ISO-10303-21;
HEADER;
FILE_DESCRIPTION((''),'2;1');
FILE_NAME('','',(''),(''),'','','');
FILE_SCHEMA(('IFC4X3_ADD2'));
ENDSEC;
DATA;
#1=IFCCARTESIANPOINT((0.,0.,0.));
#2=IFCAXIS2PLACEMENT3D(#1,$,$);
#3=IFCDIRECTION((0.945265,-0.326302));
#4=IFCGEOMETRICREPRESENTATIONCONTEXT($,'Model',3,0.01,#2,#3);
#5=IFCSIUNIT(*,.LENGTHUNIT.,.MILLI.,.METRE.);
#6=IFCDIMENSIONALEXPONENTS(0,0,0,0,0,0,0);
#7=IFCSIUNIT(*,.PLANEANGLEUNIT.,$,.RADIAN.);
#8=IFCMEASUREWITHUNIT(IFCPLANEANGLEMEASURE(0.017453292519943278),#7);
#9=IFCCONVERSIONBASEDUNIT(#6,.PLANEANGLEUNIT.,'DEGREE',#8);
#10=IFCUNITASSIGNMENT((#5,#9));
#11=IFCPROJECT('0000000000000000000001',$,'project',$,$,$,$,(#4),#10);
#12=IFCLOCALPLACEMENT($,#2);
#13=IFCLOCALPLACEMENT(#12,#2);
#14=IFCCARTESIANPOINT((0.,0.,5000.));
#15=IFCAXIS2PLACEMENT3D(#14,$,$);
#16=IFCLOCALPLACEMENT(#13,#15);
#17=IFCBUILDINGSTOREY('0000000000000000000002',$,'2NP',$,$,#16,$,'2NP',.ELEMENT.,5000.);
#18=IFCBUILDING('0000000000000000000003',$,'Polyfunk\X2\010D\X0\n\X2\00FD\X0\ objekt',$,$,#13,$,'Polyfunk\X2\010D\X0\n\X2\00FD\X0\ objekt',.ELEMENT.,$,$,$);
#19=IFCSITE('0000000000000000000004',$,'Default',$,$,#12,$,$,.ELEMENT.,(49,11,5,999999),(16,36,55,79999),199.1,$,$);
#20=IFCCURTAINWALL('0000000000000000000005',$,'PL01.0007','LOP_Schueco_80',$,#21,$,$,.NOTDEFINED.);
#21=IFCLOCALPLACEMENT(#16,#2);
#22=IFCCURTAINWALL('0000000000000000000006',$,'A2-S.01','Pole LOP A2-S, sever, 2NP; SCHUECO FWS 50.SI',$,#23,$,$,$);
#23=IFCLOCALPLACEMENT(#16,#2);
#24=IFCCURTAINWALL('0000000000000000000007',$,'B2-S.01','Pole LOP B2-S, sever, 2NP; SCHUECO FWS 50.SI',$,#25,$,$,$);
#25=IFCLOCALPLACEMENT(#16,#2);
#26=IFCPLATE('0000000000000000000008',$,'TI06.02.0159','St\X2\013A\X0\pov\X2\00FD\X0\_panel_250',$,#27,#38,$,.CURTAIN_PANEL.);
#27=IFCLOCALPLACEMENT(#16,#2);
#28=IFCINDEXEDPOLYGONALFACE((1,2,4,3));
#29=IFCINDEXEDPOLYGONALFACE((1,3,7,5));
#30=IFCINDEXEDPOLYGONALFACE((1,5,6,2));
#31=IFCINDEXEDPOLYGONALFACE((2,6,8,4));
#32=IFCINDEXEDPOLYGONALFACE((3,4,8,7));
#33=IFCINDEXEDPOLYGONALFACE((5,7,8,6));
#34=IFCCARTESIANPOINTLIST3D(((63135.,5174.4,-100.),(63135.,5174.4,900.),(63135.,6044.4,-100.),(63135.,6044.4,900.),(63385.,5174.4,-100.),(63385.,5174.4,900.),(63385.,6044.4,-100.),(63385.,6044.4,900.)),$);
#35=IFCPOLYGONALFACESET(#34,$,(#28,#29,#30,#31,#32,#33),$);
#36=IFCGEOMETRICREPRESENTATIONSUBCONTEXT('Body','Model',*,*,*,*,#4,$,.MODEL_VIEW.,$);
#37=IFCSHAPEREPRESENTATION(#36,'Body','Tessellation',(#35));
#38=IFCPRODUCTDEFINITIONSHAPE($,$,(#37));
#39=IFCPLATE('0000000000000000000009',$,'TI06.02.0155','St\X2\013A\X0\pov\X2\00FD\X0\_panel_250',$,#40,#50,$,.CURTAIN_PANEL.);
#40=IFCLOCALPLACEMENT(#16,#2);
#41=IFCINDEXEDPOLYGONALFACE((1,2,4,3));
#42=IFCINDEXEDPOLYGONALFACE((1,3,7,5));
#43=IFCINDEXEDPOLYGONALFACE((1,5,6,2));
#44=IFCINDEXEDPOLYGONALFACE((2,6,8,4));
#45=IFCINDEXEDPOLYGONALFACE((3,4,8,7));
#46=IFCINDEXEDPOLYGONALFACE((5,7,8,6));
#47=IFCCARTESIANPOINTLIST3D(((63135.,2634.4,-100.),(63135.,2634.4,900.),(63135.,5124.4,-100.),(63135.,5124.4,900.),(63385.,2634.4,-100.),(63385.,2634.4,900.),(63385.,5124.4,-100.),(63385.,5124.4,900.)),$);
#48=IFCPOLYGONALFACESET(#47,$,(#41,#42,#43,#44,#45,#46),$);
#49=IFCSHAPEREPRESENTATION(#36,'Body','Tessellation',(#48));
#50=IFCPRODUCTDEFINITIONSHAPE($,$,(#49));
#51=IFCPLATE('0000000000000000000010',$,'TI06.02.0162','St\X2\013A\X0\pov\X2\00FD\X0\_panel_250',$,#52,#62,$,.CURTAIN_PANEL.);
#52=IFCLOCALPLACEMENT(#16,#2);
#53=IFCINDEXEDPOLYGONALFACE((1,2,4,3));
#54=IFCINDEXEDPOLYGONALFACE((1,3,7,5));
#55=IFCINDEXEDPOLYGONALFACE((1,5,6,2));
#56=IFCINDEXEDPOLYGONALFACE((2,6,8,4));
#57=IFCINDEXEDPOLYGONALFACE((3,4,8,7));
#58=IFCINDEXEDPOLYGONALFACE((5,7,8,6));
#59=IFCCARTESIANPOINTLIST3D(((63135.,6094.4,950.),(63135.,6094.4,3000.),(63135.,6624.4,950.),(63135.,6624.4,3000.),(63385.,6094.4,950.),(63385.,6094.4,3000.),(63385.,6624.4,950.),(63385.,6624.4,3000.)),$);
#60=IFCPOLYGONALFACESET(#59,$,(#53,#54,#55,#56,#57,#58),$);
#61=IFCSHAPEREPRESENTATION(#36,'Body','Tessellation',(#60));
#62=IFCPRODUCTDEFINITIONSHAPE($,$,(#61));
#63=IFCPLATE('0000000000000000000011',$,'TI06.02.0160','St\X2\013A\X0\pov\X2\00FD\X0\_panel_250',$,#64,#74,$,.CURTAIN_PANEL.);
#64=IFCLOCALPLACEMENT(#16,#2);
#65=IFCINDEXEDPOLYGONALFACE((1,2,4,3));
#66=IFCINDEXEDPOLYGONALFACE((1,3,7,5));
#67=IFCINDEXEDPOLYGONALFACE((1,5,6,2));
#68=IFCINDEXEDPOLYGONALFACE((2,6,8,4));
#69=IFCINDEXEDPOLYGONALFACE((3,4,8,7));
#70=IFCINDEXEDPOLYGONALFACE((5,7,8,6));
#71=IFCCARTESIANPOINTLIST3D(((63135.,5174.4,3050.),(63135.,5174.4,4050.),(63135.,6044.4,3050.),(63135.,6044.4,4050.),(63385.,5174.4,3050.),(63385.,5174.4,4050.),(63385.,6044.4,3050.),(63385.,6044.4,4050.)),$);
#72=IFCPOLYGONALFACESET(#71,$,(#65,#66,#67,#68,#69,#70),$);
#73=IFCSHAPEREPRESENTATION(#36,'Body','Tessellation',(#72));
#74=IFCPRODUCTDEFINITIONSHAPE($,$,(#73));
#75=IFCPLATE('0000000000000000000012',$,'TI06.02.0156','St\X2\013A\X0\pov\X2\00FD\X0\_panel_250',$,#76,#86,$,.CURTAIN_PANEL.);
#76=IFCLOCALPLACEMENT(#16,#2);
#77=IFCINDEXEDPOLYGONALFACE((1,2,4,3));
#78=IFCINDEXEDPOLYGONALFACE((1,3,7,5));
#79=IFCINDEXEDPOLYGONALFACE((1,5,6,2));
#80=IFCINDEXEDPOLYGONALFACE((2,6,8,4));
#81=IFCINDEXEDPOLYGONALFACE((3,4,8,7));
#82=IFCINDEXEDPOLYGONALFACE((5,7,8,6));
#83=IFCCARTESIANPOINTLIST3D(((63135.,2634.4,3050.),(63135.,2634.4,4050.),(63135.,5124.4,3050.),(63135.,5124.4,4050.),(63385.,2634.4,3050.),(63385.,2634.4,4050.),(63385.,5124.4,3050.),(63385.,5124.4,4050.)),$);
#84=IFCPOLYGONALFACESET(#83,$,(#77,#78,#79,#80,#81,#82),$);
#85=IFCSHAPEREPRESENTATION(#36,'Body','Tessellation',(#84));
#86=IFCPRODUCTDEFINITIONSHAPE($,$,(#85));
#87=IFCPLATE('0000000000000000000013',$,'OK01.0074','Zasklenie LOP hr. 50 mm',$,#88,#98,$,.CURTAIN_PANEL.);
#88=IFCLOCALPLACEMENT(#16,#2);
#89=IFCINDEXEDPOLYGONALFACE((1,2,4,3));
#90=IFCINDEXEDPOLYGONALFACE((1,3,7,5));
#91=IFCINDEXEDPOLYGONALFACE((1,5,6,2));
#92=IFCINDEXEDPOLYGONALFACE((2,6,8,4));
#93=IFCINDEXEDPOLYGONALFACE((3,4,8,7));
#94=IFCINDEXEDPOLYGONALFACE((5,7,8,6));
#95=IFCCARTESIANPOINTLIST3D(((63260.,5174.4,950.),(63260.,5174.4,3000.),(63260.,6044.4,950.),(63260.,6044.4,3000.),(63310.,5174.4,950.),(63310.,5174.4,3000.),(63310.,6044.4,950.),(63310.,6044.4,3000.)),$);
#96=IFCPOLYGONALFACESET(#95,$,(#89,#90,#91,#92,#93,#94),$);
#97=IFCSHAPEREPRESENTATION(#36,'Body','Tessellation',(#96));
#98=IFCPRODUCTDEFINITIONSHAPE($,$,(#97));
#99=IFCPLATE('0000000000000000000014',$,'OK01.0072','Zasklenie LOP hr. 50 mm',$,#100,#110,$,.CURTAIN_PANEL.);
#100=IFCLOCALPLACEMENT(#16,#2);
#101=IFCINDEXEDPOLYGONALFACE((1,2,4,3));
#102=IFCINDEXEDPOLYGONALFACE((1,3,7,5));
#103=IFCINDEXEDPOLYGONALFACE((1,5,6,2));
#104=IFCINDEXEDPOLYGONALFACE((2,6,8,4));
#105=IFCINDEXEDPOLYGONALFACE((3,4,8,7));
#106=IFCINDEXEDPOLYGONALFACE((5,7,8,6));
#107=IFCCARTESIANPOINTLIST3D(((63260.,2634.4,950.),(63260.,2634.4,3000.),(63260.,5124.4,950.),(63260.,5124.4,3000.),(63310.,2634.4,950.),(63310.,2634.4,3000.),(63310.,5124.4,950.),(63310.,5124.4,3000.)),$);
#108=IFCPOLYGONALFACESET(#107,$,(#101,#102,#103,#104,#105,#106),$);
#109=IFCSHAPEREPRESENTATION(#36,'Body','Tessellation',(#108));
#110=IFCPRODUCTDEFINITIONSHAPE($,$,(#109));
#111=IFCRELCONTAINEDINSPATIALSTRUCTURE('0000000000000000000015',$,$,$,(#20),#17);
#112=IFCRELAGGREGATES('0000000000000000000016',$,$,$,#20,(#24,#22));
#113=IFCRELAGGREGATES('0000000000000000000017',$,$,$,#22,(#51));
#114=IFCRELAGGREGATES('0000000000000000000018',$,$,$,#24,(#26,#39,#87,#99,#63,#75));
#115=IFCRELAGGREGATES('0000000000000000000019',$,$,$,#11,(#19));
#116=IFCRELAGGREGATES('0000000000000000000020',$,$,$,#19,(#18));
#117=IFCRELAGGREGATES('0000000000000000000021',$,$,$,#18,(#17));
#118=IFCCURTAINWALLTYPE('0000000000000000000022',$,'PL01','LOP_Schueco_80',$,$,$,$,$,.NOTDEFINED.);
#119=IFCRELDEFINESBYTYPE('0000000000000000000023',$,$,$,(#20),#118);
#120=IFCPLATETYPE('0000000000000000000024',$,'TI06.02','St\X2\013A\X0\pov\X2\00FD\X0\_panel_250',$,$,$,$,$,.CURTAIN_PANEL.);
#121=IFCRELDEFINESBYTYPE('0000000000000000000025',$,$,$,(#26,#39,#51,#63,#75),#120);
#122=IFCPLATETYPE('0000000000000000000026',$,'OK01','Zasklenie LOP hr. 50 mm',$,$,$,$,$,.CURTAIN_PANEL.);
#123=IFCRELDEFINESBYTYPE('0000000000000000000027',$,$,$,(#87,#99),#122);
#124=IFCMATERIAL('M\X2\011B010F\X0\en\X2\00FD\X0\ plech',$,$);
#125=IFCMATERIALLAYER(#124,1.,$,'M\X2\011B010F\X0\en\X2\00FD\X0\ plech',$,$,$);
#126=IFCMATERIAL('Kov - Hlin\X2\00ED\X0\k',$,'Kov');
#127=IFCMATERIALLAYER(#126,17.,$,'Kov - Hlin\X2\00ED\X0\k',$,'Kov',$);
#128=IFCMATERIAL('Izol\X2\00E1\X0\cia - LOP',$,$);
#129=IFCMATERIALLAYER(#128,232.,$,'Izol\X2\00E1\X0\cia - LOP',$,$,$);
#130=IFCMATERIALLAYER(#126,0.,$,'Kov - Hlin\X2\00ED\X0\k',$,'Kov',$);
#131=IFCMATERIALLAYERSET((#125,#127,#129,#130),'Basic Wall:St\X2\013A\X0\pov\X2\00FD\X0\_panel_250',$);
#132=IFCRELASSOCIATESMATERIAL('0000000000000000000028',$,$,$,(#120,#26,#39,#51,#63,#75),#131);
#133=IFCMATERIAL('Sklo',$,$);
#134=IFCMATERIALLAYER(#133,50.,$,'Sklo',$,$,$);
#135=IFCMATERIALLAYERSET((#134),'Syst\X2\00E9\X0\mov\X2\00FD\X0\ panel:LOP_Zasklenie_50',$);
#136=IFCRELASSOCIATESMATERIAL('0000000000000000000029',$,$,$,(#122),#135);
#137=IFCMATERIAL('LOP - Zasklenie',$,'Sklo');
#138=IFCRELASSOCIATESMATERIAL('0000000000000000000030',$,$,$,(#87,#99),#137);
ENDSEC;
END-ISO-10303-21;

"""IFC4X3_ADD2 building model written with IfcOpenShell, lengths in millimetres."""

from ifc_helpers import new_model, entity, si_unit, converted_unit, direction, frame, frame_2d, origin, origin_2d_with_axis, place, context, subcontext, project, spatial, rectangle, extrude, source, transform, mapped, material, layer, layer_set, layer_usage, type_object, type_shapes, element, aggregate, save


model = new_model("IFC4X3_ADD2")

# Units and contexts
model_context = context("Model", 3, precision=0.01, world=origin(), true_north=direction((0.945265, -0.326302)))
body_context = subcontext(model_context, "Body", "Model", "MODEL_VIEW")
ifc_project = project(units=[si_unit("LENGTHUNIT", "METRE", prefix="MILLI"), converted_unit("PLANEANGLEUNIT", "DEGREE", entity("IfcPlaneAngleMeasure", 0.017453292519943278), si_unit("PLANEANGLEUNIT", "RADIAN"), dimensions=[0, 0, 0, 0, 0, 0, 0])], contexts=[model_context])

# Site, building, storey
site_placement = place(None, origin())
site = spatial("IfcSite", under=ifc_project, at=site_placement, Name="Default", CompositionType="ELEMENT", RefLatitude=(49, 11, 5, 999999), RefLongitude=(16, 36, 55, 79999), RefElevation=199.1)
building_placement = place(site_placement, origin())
building = spatial("IfcBuilding", under=site, at=building_placement, Name="Polyfunkčný objekt", LongName="Polyfunkčný objekt", CompositionType="ELEMENT")
storey_placement = place(building_placement, frame((0.0, 0.0, 5000.0)))
storey = spatial("IfcBuildingStorey", under=building, at=storey_placement, Name="2NP", LongName="2NP", CompositionType="ELEMENT", Elevation=5000.0)

# Curtain walls, plates
curtain_wall_type = type_object("IfcCurtainWallType", Name="PL01", Description="LOP_Schueco_80", PredefinedType="NOTDEFINED")
curtain_wall_1_placement = place(storey_placement, frame((0.0, 0.0, -5000.0)))
curtain_wall_1 = element("IfcCurtainWall", 1, at=curtain_wall_1_placement, inside=storey, type_object=curtain_wall_type, Name="PL01.0007", Description="LOP_Schueco_80", PredefinedType="NOTDEFINED")
curtain_wall_2 = element("IfcCurtainWall", 2, Name="A2-S.01", Description="Pole LOP A2-S, sever, 2NP; SCHUECO FWS 50.SI")
curtain_wall_3 = element("IfcCurtainWall", 3, Name="B2-S.01", Description="Pole LOP B2-S, sever, 2NP; SCHUECO FWS 50.SI")
aggregate(curtain_wall_1, [curtain_wall_3, curtain_wall_2])
ifc_material_1 = material(Name="Měďený plech")
ifc_layer_1 = layer(ifc_material_1, 1.0, Name="Měďený plech")
ifc_material_2 = material(Name="Kov - Hliník", Category="Kov")
ifc_layer_2 = layer(ifc_material_2, 17.0, Name="Kov - Hliník", Category="Kov")
ifc_material_3 = material(Name="Izolácia - LOP")
ifc_layer_3 = layer(ifc_material_3, 232.0, Name="Izolácia - LOP")
ifc_layer_4 = layer(ifc_material_2, 0.0, Name="Kov - Hliník", Category="Kov")
ifc_layer_set_1 = layer_set([ifc_layer_1, ifc_layer_2, ifc_layer_3, ifc_layer_4], Name="Basic Wall:Stĺpový_panel_250")
ifc_layer_usage_1 = layer_usage(ifc_layer_set_1, "AXIS2", "NEGATIVE", 125.0)
plate_type_1 = type_object("IfcPlateType", Name="TI06.02", Description="Stĺpový_panel_250", PredefinedType="CURTAIN_PANEL", material=ifc_layer_set_1)
plate_1_placement = place(storey_placement, frame((63260.0, 6044.4, -100.0), z_axis=(0.0, 0.0, 1.0), x_axis=(0.0, -1.0, 0.0)))
plate_1 = element("IfcPlate", 4, at=plate_1_placement, type_object=plate_type_1, material=ifc_layer_usage_1, Name="TI06.02.0159", Description="Stĺpový_panel_250", PredefinedType="CURTAIN_PANEL", context=body_context, shape_type="SweptSolid", body=[
    extrude(rectangle(XDim=250.0, YDim=870.0, at=frame_2d((0.0, 0.0), x_axis=(1.0, 0.0))), frame((435.0, 0.0, 0.0), z_axis=(0.0, 0.0, 1.0), x_axis=(0.0, 1.0, 0.0)), (0.0, 0.0, 1.0), 1000.0),
])
ifc_layer_usage_2 = layer_usage(ifc_layer_set_1, "AXIS2", "NEGATIVE", 125.0)
plate_2_placement = place(storey_placement, frame((63260.0, 5124.4, -100.0), z_axis=(0.0, 0.0, 1.0), x_axis=(0.0, -1.0, 0.0)))
plate_2 = element("IfcPlate", 5, at=plate_2_placement, type_object=plate_type_1, material=ifc_layer_usage_2, Name="TI06.02.0155", Description="Stĺpový_panel_250", PredefinedType="CURTAIN_PANEL", context=body_context, shape_type="SweptSolid", body=[
    extrude(rectangle(XDim=250.0, YDim=2490.0, at=origin_2d_with_axis()), frame((1245.0, 0.0, 0.0), z_axis=(0.0, 0.0, 1.0), x_axis=(0.0, 1.0, 0.0)), (0.0, 0.0, 1.0), 1000.0),
])
ifc_layer_usage_3 = layer_usage(ifc_layer_set_1, "AXIS2", "NEGATIVE", 125.0)
plate_3_placement = place(storey_placement, frame((63260.0, 6624.4, 950.0), z_axis=(0.0, 0.0, 1.0), x_axis=(0.0, -1.0, 0.0)))
plate_3 = element("IfcPlate", 6, at=plate_3_placement, type_object=plate_type_1, material=ifc_layer_usage_3, Name="TI06.02.0162", Description="Stĺpový_panel_250", PredefinedType="CURTAIN_PANEL", context=body_context, shape_type="SweptSolid", body=[
    extrude(rectangle(XDim=250.0, YDim=530.0, at=frame_2d((0.0, 0.0), x_axis=(1.0, 0.0))), frame((265.0, 0.0, 0.0), z_axis=(0.0, 0.0, 1.0), x_axis=(0.0, 1.0, 0.0)), (0.0, 0.0, 1.0), 2050.0),
])
aggregate(curtain_wall_2, [plate_3])
ifc_layer_usage_4 = layer_usage(ifc_layer_set_1, "AXIS2", "NEGATIVE", 125.0)
plate_4_placement = place(storey_placement, frame((63260.0, 6044.4, 3050.0), z_axis=(0.0, 0.0, 1.0), x_axis=(0.0, -1.0, 0.0)))
plate_4 = element("IfcPlate", 7, at=plate_4_placement, type_object=plate_type_1, material=ifc_layer_usage_4, Name="TI06.02.0160", Description="Stĺpový_panel_250", PredefinedType="CURTAIN_PANEL", context=body_context, shape_type="SweptSolid", body=[
    extrude(rectangle(XDim=250.0, YDim=870.0, at=frame_2d((0.0, 0.0), x_axis=(1.0, 0.0))), frame((435.0, 0.0, 0.0), z_axis=(0.0, 0.0, 1.0), x_axis=(0.0, 1.0, 0.0)), (0.0, 0.0, 1.0), 1000.0),
])
ifc_layer_usage_5 = layer_usage(ifc_layer_set_1, "AXIS2", "NEGATIVE", 125.0)
plate_5_placement = place(storey_placement, frame((63260.0, 5124.4, 3050.0), z_axis=(0.0, 0.0, 1.0), x_axis=(0.0, -1.0, 0.0)))
plate_5 = element("IfcPlate", 8, at=plate_5_placement, type_object=plate_type_1, material=ifc_layer_usage_5, Name="TI06.02.0156", Description="Stĺpový_panel_250", PredefinedType="CURTAIN_PANEL", context=body_context, shape_type="SweptSolid", body=[
    extrude(rectangle(XDim=250.0, YDim=2490.0, at=frame_2d((0.0, 0.0), x_axis=(1.0, 0.0))), frame((1245.0, 0.0, 0.0), z_axis=(0.0, 0.0, 1.0), x_axis=(0.0, 1.0, 0.0)), (0.0, 0.0, 1.0), 1000.0),
])
ifc_material_4 = material(Name="LOP - Zasklenie", Category="Sklo")
ifc_material_5 = material(Name="Sklo")
ifc_layer_5 = layer(ifc_material_5, 50.0, Name="Sklo")
ifc_layer_set_2 = layer_set([ifc_layer_5], Name="Systémový panel:LOP_Zasklenie_50")
plate_type_2 = type_object("IfcPlateType", Name="OK01", Description="Zasklenie LOP hr. 50 mm", PredefinedType="CURTAIN_PANEL", material=ifc_layer_set_2)
shared_shape_1 = source(origin(), body_context, "Body", "SweptSolid", [
    extrude(rectangle(XDim=50.0, YDim=870.0, at=origin_2d_with_axis()), frame((0.0, 25.0, 0.0), z_axis=(0.0, 0.0, 1.0), x_axis=(0.0, 1.0, 0.0)), (0.0, 0.0, 1.0), 2050.0),
])
plate_6_placement = place(curtain_wall_1_placement, frame((63260.0, 5609.4, 5950.0), z_axis=(0.0, 0.0, 1.0), x_axis=(0.0, -1.0, 0.0)))
plate_6 = element("IfcPlate", 9, at=plate_6_placement, type_object=plate_type_2, material=ifc_material_4, Name="OK01.0074", Description="Zasklenie LOP hr. 50 mm", PredefinedType="CURTAIN_PANEL", context=body_context, shape_type="MappedRepresentation", body=[
    mapped(shared_shape_1, transform((0.0, 0.0, 0.0), scale=1.0)),
])
shared_shape_2 = source(origin(), body_context, "Body", "SweptSolid", [
    extrude(rectangle(XDim=50.0, YDim=2490.0, at=origin_2d_with_axis()), frame((0.0, 25.0, 0.0), z_axis=(0.0, 0.0, 1.0), x_axis=(0.0, 1.0, 0.0)), (0.0, 0.0, 1.0), 2050.0),
])
type_shapes(plate_type_2, [shared_shape_1, shared_shape_2])
plate_7_placement = place(curtain_wall_1_placement, frame((63260.0, 3879.4, 5950.0), z_axis=(0.0, 0.0, 1.0), x_axis=(0.0, -1.0, 0.0)))
plate_7 = element("IfcPlate", 10, at=plate_7_placement, type_object=plate_type_2, material=ifc_material_4, Name="OK01.0072", Description="Zasklenie LOP hr. 50 mm", PredefinedType="CURTAIN_PANEL", context=body_context, shape_type="MappedRepresentation", body=[
    mapped(shared_shape_2, transform((0.0, 0.0, 0.0), scale=1.0)),
])
aggregate(curtain_wall_3, [plate_1, plate_2, plate_6, plate_7, plate_4, plate_5])

save(model, "model.ifc")
